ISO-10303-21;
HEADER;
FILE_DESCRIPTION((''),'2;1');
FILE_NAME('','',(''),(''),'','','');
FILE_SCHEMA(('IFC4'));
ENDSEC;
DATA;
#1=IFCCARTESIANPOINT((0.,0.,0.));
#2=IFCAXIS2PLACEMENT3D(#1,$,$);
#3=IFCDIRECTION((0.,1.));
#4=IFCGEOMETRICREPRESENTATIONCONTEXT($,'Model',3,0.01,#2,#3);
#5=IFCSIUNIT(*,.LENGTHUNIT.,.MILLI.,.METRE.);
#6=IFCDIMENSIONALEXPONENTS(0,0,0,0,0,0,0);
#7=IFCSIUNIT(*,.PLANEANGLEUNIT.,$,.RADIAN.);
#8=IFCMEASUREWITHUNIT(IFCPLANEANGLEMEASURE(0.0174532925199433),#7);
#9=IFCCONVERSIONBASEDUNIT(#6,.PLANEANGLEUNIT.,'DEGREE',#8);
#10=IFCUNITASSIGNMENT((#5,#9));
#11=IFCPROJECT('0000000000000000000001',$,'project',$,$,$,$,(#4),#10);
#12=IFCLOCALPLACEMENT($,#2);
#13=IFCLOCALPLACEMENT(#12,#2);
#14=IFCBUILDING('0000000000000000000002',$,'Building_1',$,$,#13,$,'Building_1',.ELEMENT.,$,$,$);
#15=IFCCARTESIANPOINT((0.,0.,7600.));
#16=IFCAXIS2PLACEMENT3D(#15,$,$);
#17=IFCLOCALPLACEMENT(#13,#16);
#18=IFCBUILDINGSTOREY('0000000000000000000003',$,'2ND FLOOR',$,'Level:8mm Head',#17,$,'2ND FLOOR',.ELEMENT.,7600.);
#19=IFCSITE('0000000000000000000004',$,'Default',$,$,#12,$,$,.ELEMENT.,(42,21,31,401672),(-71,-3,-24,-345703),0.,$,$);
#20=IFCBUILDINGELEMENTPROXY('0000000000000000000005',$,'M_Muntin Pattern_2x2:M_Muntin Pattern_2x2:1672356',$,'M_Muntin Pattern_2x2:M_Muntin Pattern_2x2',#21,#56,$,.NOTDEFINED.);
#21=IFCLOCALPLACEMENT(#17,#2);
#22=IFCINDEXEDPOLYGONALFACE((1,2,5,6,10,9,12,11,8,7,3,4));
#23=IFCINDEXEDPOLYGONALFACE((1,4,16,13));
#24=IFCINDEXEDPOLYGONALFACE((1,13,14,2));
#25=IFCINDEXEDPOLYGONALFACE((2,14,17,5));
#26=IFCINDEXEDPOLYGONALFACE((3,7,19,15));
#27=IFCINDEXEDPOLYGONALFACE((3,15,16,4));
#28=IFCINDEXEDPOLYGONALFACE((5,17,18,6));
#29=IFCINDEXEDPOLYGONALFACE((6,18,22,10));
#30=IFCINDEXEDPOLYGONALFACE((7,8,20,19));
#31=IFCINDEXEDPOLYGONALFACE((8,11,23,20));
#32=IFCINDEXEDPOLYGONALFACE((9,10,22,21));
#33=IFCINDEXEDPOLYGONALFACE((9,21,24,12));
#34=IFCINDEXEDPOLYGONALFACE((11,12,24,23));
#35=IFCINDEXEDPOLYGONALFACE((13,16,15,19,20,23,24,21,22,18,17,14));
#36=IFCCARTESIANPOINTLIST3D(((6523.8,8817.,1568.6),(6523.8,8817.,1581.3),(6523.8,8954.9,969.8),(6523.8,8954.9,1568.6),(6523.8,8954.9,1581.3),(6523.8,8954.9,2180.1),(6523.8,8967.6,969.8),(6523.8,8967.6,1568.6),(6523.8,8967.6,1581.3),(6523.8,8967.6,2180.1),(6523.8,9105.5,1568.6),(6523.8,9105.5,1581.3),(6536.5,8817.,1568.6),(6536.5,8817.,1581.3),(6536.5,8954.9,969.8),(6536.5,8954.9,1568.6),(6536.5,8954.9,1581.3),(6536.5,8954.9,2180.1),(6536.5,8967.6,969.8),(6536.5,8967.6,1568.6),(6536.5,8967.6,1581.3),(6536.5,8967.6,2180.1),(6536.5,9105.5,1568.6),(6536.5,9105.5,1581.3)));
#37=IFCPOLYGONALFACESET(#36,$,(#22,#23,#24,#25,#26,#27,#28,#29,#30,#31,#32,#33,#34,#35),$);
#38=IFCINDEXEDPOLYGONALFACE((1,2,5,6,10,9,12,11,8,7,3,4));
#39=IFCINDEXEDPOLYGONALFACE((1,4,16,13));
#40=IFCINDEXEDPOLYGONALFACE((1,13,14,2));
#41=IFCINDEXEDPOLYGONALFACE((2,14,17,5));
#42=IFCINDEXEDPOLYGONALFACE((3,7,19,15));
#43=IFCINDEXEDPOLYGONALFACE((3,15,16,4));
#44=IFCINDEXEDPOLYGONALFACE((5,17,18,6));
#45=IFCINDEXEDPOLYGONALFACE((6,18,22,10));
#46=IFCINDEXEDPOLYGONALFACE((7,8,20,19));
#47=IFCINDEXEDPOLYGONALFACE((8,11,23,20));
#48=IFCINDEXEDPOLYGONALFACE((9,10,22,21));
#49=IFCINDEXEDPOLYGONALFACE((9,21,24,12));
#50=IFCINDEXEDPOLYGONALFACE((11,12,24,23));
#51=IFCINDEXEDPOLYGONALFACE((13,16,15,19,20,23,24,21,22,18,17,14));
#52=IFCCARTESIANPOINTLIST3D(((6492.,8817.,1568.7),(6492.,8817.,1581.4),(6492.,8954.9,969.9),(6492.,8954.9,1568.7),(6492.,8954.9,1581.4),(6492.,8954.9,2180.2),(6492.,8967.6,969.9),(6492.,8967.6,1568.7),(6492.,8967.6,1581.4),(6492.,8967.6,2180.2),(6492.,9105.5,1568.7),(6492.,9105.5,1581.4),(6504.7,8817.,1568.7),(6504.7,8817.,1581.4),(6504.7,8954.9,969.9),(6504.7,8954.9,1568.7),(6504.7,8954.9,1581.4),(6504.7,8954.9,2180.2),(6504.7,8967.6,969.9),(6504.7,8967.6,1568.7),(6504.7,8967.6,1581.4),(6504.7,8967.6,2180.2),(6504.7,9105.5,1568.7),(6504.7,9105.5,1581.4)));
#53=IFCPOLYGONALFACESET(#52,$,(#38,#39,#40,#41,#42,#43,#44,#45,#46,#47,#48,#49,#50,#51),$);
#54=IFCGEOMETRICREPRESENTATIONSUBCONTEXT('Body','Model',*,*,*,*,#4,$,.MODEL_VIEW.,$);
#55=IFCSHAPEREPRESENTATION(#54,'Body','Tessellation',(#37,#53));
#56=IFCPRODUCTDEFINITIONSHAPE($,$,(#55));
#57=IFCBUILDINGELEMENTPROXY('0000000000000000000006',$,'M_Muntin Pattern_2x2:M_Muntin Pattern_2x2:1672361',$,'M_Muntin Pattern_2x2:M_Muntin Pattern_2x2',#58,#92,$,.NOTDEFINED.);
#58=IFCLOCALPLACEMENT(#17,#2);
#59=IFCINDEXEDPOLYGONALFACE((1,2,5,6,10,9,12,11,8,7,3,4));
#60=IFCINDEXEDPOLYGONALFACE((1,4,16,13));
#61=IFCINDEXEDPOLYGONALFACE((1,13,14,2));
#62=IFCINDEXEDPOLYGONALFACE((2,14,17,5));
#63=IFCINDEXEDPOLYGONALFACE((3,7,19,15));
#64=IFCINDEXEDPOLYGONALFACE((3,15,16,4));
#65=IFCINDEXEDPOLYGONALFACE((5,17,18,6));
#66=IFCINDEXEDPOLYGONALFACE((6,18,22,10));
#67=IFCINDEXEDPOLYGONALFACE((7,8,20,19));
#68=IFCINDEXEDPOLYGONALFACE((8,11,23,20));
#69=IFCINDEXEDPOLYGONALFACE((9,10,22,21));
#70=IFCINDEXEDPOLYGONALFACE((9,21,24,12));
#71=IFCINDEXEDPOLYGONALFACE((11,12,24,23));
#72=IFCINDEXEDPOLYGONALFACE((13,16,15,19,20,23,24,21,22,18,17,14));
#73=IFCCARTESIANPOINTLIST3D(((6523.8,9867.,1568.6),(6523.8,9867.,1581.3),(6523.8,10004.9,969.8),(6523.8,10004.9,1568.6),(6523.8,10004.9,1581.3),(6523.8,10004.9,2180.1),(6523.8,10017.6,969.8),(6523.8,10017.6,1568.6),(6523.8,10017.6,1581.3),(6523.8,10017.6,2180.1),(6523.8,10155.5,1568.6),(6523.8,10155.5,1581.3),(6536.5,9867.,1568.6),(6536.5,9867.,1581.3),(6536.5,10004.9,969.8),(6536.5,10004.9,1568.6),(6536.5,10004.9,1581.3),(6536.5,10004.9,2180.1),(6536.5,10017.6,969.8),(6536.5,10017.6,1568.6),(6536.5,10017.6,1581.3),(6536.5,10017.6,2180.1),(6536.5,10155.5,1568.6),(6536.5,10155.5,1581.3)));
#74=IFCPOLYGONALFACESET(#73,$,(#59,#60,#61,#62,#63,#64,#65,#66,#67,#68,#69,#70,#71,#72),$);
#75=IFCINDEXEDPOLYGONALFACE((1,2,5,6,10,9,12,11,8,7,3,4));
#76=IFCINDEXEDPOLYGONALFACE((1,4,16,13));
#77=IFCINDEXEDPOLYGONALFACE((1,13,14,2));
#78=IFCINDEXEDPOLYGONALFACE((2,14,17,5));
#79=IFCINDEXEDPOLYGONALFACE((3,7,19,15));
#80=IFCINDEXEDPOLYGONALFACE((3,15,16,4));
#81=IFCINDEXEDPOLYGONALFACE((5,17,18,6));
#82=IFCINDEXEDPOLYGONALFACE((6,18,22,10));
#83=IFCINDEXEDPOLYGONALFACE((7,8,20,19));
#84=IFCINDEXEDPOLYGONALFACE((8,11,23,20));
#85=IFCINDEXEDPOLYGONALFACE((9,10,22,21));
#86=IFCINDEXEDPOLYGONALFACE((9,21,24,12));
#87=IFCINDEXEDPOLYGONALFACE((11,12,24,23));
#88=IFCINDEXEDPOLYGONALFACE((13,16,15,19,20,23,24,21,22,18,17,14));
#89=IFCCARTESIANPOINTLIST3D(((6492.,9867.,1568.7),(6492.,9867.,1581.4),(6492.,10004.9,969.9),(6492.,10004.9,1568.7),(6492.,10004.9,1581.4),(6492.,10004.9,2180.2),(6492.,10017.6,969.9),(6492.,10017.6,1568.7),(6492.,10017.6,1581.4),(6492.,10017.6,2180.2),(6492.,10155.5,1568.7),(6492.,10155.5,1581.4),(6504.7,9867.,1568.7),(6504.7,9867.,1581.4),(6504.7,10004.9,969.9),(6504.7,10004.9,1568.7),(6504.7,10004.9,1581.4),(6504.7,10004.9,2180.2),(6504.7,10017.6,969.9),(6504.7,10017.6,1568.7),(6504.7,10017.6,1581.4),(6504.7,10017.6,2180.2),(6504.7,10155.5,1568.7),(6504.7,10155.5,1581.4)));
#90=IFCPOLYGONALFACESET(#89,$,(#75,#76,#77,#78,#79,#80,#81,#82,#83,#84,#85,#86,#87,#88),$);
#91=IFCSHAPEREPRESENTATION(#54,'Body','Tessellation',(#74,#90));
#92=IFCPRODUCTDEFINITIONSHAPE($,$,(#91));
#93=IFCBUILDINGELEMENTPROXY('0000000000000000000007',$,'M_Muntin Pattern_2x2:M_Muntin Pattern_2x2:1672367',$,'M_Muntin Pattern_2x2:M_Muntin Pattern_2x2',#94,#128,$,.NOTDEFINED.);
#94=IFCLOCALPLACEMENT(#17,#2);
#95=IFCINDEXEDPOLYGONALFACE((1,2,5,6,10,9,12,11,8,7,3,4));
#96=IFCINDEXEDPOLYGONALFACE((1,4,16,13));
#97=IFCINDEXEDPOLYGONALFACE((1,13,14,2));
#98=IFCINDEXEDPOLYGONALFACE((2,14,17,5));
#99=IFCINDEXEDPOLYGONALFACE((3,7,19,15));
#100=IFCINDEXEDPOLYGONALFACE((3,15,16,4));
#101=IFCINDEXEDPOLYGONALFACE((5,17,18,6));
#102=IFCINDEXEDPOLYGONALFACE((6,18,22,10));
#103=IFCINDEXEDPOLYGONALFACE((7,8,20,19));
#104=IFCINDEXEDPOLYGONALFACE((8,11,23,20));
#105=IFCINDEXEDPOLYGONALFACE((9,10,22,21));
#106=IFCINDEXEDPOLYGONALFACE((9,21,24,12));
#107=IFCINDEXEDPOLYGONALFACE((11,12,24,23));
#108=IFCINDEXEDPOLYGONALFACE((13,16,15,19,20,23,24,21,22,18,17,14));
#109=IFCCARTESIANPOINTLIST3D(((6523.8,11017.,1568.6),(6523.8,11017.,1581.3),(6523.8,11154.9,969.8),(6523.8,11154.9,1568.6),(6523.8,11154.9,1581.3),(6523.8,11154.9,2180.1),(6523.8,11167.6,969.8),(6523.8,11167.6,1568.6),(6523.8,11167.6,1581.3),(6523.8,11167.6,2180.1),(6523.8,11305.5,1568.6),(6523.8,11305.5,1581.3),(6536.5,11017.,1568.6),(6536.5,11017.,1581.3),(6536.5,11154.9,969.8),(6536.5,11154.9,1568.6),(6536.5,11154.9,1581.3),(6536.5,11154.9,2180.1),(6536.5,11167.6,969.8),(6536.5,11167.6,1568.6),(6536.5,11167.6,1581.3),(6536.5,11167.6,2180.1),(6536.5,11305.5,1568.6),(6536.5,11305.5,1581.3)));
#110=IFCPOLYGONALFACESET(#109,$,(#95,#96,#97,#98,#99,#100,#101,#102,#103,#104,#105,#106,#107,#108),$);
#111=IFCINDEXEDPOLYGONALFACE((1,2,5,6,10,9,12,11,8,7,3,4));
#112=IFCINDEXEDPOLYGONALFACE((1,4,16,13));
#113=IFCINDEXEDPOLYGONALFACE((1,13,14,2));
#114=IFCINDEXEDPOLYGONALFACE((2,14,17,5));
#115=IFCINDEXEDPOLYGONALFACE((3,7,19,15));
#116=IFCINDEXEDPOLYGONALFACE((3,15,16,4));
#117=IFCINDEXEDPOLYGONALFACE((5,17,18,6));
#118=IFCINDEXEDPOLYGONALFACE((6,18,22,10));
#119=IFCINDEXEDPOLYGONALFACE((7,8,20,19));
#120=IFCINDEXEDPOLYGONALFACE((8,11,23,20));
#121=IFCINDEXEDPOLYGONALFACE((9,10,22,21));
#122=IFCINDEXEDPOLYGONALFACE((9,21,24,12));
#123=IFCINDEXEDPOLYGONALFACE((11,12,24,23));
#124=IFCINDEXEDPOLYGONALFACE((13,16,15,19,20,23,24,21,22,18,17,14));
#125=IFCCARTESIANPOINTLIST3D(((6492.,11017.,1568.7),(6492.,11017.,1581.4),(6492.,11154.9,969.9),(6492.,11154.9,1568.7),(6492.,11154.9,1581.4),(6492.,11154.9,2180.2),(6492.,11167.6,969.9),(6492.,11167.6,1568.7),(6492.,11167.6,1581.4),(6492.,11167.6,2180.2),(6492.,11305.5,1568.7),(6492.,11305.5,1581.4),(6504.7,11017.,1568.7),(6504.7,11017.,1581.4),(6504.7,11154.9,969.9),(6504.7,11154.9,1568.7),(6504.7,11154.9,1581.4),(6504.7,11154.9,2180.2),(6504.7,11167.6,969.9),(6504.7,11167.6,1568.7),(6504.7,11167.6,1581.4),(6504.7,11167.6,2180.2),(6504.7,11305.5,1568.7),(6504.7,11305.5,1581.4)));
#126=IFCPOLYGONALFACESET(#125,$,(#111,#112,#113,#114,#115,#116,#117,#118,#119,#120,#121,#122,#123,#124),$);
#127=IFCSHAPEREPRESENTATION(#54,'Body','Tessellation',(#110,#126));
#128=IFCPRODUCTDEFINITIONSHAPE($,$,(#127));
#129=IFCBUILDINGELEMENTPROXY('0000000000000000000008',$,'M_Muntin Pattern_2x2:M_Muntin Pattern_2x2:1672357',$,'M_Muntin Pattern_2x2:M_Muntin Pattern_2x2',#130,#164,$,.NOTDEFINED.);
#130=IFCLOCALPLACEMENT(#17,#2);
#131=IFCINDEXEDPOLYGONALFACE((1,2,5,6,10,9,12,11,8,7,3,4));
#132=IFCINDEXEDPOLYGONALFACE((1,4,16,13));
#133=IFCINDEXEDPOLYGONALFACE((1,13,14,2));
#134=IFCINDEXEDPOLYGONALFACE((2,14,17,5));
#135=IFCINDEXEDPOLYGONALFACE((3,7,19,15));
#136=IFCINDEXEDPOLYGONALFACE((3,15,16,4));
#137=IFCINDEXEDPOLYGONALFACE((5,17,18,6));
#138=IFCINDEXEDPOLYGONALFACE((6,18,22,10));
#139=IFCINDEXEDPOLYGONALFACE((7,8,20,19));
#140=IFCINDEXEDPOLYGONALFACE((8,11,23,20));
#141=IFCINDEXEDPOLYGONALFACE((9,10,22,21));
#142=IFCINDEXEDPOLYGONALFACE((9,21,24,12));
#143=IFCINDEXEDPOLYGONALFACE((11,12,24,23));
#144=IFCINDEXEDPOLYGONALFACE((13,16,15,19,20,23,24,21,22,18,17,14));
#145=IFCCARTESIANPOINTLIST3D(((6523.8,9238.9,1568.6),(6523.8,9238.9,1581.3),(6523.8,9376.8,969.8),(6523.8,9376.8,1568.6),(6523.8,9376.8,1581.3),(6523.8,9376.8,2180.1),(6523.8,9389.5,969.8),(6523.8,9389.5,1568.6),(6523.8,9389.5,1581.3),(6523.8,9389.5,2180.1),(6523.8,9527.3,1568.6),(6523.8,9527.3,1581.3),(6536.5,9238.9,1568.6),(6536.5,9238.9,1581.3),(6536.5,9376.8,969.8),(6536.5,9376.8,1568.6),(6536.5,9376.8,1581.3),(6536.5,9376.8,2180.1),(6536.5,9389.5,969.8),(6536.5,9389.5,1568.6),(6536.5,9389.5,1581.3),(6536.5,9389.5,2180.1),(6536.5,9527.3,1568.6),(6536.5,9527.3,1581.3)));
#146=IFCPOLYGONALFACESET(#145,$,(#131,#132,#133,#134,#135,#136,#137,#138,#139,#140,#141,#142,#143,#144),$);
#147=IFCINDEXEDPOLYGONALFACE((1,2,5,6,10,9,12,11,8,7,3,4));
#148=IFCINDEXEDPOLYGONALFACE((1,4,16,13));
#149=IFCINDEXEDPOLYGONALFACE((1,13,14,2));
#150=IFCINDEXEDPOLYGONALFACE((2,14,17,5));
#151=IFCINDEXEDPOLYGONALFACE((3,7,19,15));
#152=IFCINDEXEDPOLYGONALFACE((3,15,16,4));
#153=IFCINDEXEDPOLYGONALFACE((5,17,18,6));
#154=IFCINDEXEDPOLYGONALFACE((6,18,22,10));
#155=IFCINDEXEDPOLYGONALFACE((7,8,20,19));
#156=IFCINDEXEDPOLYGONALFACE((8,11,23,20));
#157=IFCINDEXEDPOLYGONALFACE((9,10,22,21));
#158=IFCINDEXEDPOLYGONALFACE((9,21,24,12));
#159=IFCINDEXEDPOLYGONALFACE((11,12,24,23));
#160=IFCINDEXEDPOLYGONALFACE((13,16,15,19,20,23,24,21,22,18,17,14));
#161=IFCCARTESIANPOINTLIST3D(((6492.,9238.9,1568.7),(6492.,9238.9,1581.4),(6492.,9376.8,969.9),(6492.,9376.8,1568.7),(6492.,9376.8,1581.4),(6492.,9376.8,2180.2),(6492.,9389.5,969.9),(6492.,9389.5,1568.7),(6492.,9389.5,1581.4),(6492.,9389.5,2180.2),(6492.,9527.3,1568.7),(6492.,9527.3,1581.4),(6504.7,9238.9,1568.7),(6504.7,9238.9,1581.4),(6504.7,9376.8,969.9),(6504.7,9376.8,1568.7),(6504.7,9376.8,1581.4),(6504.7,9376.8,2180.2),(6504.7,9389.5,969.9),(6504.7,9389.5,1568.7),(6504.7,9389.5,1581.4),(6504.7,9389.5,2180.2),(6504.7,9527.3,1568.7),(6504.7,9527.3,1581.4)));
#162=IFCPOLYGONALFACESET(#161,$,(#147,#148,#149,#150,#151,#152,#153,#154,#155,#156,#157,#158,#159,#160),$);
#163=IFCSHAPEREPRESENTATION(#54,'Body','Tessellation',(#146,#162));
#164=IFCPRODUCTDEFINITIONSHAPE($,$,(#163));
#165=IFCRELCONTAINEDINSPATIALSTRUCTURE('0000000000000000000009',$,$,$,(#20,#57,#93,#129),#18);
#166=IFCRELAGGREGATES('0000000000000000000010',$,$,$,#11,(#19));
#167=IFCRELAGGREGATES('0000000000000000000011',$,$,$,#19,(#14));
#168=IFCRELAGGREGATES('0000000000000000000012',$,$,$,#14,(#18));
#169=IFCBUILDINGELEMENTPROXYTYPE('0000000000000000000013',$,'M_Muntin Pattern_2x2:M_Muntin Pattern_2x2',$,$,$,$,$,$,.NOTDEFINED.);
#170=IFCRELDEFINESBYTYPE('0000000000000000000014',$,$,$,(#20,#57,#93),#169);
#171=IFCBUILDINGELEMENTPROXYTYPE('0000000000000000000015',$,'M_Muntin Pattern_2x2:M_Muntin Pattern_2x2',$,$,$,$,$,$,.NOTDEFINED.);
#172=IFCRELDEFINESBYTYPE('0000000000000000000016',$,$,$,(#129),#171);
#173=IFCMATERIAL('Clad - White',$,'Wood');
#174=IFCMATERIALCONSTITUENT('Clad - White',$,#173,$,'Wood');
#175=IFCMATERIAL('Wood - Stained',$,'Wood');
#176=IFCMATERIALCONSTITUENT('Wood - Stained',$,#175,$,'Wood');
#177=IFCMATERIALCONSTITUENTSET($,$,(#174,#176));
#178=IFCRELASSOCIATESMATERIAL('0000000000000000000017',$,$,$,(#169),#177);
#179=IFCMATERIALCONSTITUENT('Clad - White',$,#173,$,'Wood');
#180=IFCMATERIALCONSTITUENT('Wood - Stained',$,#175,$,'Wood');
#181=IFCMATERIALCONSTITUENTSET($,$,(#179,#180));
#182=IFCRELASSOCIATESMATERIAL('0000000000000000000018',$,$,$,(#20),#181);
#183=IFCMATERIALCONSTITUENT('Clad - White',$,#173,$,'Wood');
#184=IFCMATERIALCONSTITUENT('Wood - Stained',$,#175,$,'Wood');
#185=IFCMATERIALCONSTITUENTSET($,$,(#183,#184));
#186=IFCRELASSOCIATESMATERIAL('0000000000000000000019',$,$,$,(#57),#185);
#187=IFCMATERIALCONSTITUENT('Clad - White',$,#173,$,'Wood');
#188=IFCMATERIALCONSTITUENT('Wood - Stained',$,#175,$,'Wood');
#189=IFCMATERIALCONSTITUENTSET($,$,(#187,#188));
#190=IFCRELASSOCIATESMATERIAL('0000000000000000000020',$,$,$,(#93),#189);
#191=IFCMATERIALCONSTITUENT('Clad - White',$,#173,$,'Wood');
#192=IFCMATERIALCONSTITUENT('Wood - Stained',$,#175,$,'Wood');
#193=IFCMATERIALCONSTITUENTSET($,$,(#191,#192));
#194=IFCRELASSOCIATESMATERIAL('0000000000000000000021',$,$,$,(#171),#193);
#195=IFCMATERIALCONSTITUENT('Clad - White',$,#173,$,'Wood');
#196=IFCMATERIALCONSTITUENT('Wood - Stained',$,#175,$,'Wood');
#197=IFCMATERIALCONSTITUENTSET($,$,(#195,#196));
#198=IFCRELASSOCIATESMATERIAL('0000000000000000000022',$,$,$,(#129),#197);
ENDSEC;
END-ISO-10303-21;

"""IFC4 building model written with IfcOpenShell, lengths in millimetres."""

from ifc_helpers import new_model, entity, si_unit, converted_unit, direction, frame, origin, place, context, subcontext, project, spatial, indexed_curve, outline, extrude, source, transform, mapped, material, constituent, constituent_set, type_object, type_shapes, element, save


model = new_model("IFC4")

# Units and contexts
model_context = context("Model", 3, precision=0.01, world=origin(), true_north=direction((0.0, 1.0)))
body_context = subcontext(model_context, "Body", "Model", "MODEL_VIEW")
ifc_project = project(units=[si_unit("LENGTHUNIT", "METRE", prefix="MILLI"), converted_unit("PLANEANGLEUNIT", "DEGREE", entity("IfcPlaneAngleMeasure", 0.0174532925199433), si_unit("PLANEANGLEUNIT", "RADIAN"), dimensions=[0, 0, 0, 0, 0, 0, 0])], contexts=[model_context])

# Site, building, storey
site_placement = place(None, origin())
site = spatial("IfcSite", under=ifc_project, at=site_placement, Name="Default", CompositionType="ELEMENT", RefLatitude=(42, 21, 31, 401672), RefLongitude=(-71, -3, -24, -345703), RefElevation=0.0)
building_placement = place(site_placement, origin())
building = spatial("IfcBuilding", under=site, at=building_placement, Name="Building_1", LongName="Building_1", CompositionType="ELEMENT")
storey_placement = place(building_placement, frame((0.0, 0.0, 7600.0)))
storey = spatial("IfcBuildingStorey", under=building, at=storey_placement, Name="2ND FLOOR", ObjectType="Level:8mm Head", LongName="2ND FLOOR", CompositionType="ELEMENT", Elevation=7600.0)

# Building element proxies
ifc_material_1 = material(Name="Clad - White", Category="Wood")
ifc_constituent_1 = constituent(ifc_material_1, Name="Clad - White", Category="Wood")
ifc_material_2 = material(Name="Wood - Stained", Category="Wood")
ifc_constituent_2 = constituent(ifc_material_2, Name="Wood - Stained", Category="Wood")
ifc_constituent_set_1 = constituent_set(constituents=[ifc_constituent_1, ifc_constituent_2])
ifc_constituent_3 = constituent(ifc_material_1, Name="Clad - White", Category="Wood")
ifc_constituent_4 = constituent(ifc_material_2, Name="Wood - Stained", Category="Wood")
ifc_constituent_set_2 = constituent_set(constituents=[ifc_constituent_3, ifc_constituent_4])
building_element_proxy_type_1 = type_object("IfcBuildingElementProxyType", Name="M_Muntin Pattern_2x2:M_Muntin Pattern_2x2", PredefinedType="NOTDEFINED", material=ifc_constituent_set_2)
shared_shape_1 = source(origin(), body_context, "Body", "SweptSolid", [
    extrude(outline(indexed_curve([(6.4, -6.4), (605.1, -6.4), (605.1, 6.3), (6.4, 6.3), (6.4, 144.2), (-6.3, 144.2), (-6.3, 6.3), (-605.2, 6.3), (-605.2, -6.4), (-6.3, -6.4), (-6.3, -144.2), (6.4, -144.2), (6.4, -6.4)], self_intersect=False)), frame((0.0, -22.2, 605.1), z_axis=(0.0, 1.0, 0.0), x_axis=(0.0, 0.0, 1.0)), (0.0, 0.0, 1.0), 12.7),
    extrude(outline(indexed_curve([(6.4, -6.4), (605.2, -6.4), (605.2, 6.3), (6.4, 6.3), (6.4, 144.2), (-6.3, 144.2), (-6.3, 6.3), (-605.2, 6.3), (-605.2, -6.4), (-6.3, -6.4), (-6.3, -144.2), (6.4, -144.2), (6.4, -6.4)], self_intersect=False)), frame((0.0, 9.5, 605.2), z_axis=(0.0, 1.0, 0.0), x_axis=(0.0, 0.0, 1.0)), (0.0, 0.0, 1.0), 12.7),
])
type_shapes(building_element_proxy_type_1, [shared_shape_1])
proxy_1_placement = place(storey_placement, frame((6514.3, 8961.3, 969.9), z_axis=(0.0, 0.0, 1.0), x_axis=(0.0, 1.0, 0.0)))
element("IfcBuildingElementProxy", 1, at=proxy_1_placement, inside=storey, type_object=building_element_proxy_type_1, material=ifc_constituent_set_1, Name="M_Muntin Pattern_2x2:M_Muntin Pattern_2x2:1672356", ObjectType="M_Muntin Pattern_2x2:M_Muntin Pattern_2x2", PredefinedType="NOTDEFINED", context=body_context, shape_type="MappedRepresentation", body=[
    mapped(shared_shape_1, transform((0.0, 0.0, 0.0), scale=1.0)),
])
ifc_constituent_5 = constituent(ifc_material_1, Name="Clad - White", Category="Wood")
ifc_constituent_6 = constituent(ifc_material_2, Name="Wood - Stained", Category="Wood")
ifc_constituent_set_3 = constituent_set(constituents=[ifc_constituent_5, ifc_constituent_6])
proxy_2_placement = place(storey_placement, frame((6514.3, 10011.3, 969.9), z_axis=(0.0, 0.0, 1.0), x_axis=(0.0, 1.0, 0.0)))
element("IfcBuildingElementProxy", 2, at=proxy_2_placement, inside=storey, type_object=building_element_proxy_type_1, material=ifc_constituent_set_3, Name="M_Muntin Pattern_2x2:M_Muntin Pattern_2x2:1672361", ObjectType="M_Muntin Pattern_2x2:M_Muntin Pattern_2x2", PredefinedType="NOTDEFINED", context=body_context, shape_type="MappedRepresentation", body=[
    mapped(shared_shape_1, transform((0.0, 0.0, 0.0), scale=1.0)),
])
ifc_constituent_7 = constituent(ifc_material_1, Name="Clad - White", Category="Wood")
ifc_constituent_8 = constituent(ifc_material_2, Name="Wood - Stained", Category="Wood")
ifc_constituent_set_4 = constituent_set(constituents=[ifc_constituent_7, ifc_constituent_8])
proxy_3_placement = place(storey_placement, frame((6514.3, 11161.3, 969.9), z_axis=(0.0, 0.0, 1.0), x_axis=(0.0, 1.0, 0.0)))
element("IfcBuildingElementProxy", 3, at=proxy_3_placement, inside=storey, type_object=building_element_proxy_type_1, material=ifc_constituent_set_4, Name="M_Muntin Pattern_2x2:M_Muntin Pattern_2x2:1672367", ObjectType="M_Muntin Pattern_2x2:M_Muntin Pattern_2x2", PredefinedType="NOTDEFINED", context=body_context, shape_type="MappedRepresentation", body=[
    mapped(shared_shape_1, transform((0.0, 0.0, 0.0), scale=1.0)),
])
ifc_constituent_9 = constituent(ifc_material_1, Name="Clad - White", Category="Wood")
ifc_constituent_10 = constituent(ifc_material_2, Name="Wood - Stained", Category="Wood")
ifc_constituent_set_5 = constituent_set(constituents=[ifc_constituent_9, ifc_constituent_10])
ifc_constituent_11 = constituent(ifc_material_1, Name="Clad - White", Category="Wood")
ifc_constituent_12 = constituent(ifc_material_2, Name="Wood - Stained", Category="Wood")
ifc_constituent_set_6 = constituent_set(constituents=[ifc_constituent_11, ifc_constituent_12])
building_element_proxy_type_2 = type_object("IfcBuildingElementProxyType", Name="M_Muntin Pattern_2x2:M_Muntin Pattern_2x2", PredefinedType="NOTDEFINED", material=ifc_constituent_set_6)
shared_shape_2 = source(origin(), body_context, "Body", "SweptSolid", [
    extrude(outline(indexed_curve([(6.4, -6.4), (605.1, -6.4), (605.1, 6.3), (6.4, 6.3), (6.4, 144.2), (-6.3, 144.2), (-6.3, 6.3), (-605.2, 6.3), (-605.2, -6.4), (-6.3, -6.4), (-6.3, -144.2), (6.4, -144.2), (6.4, -6.4)], self_intersect=False)), frame((0.0, 9.5, 605.1), z_axis=(0.0, 1.0, 0.0), x_axis=(0.0, 0.0, 1.0)), (0.0, 0.0, 1.0), 12.7),
    extrude(outline(indexed_curve([(6.4, -6.4), (605.2, -6.4), (605.2, 6.3), (6.4, 6.3), (6.4, 144.2), (-6.3, 144.2), (-6.3, 6.3), (-605.2, 6.3), (-605.2, -6.4), (-6.3, -6.4), (-6.3, -144.2), (6.4, -144.2), (6.4, -6.4)], self_intersect=False)), frame((0.0, -22.2, 605.2), z_axis=(0.0, 1.0, 0.0), x_axis=(0.0, 0.0, 1.0)), (0.0, 0.0, 1.0), 12.7),
])
type_shapes(building_element_proxy_type_2, [shared_shape_2])
proxy_4_placement = place(storey_placement, frame((6514.3, 9383.1, 969.9), z_axis=(0.0, 0.0, 1.0), x_axis=(0.0, -1.0, 0.0)))
element("IfcBuildingElementProxy", 4, at=proxy_4_placement, inside=storey, type_object=building_element_proxy_type_2, material=ifc_constituent_set_5, Name="M_Muntin Pattern_2x2:M_Muntin Pattern_2x2:1672357", ObjectType="M_Muntin Pattern_2x2:M_Muntin Pattern_2x2", PredefinedType="NOTDEFINED", context=body_context, shape_type="MappedRepresentation", body=[
    mapped(shared_shape_2, transform((0.0, 0.0, 0.0), scale=1.0)),
])

save(model, "model.ifc")
